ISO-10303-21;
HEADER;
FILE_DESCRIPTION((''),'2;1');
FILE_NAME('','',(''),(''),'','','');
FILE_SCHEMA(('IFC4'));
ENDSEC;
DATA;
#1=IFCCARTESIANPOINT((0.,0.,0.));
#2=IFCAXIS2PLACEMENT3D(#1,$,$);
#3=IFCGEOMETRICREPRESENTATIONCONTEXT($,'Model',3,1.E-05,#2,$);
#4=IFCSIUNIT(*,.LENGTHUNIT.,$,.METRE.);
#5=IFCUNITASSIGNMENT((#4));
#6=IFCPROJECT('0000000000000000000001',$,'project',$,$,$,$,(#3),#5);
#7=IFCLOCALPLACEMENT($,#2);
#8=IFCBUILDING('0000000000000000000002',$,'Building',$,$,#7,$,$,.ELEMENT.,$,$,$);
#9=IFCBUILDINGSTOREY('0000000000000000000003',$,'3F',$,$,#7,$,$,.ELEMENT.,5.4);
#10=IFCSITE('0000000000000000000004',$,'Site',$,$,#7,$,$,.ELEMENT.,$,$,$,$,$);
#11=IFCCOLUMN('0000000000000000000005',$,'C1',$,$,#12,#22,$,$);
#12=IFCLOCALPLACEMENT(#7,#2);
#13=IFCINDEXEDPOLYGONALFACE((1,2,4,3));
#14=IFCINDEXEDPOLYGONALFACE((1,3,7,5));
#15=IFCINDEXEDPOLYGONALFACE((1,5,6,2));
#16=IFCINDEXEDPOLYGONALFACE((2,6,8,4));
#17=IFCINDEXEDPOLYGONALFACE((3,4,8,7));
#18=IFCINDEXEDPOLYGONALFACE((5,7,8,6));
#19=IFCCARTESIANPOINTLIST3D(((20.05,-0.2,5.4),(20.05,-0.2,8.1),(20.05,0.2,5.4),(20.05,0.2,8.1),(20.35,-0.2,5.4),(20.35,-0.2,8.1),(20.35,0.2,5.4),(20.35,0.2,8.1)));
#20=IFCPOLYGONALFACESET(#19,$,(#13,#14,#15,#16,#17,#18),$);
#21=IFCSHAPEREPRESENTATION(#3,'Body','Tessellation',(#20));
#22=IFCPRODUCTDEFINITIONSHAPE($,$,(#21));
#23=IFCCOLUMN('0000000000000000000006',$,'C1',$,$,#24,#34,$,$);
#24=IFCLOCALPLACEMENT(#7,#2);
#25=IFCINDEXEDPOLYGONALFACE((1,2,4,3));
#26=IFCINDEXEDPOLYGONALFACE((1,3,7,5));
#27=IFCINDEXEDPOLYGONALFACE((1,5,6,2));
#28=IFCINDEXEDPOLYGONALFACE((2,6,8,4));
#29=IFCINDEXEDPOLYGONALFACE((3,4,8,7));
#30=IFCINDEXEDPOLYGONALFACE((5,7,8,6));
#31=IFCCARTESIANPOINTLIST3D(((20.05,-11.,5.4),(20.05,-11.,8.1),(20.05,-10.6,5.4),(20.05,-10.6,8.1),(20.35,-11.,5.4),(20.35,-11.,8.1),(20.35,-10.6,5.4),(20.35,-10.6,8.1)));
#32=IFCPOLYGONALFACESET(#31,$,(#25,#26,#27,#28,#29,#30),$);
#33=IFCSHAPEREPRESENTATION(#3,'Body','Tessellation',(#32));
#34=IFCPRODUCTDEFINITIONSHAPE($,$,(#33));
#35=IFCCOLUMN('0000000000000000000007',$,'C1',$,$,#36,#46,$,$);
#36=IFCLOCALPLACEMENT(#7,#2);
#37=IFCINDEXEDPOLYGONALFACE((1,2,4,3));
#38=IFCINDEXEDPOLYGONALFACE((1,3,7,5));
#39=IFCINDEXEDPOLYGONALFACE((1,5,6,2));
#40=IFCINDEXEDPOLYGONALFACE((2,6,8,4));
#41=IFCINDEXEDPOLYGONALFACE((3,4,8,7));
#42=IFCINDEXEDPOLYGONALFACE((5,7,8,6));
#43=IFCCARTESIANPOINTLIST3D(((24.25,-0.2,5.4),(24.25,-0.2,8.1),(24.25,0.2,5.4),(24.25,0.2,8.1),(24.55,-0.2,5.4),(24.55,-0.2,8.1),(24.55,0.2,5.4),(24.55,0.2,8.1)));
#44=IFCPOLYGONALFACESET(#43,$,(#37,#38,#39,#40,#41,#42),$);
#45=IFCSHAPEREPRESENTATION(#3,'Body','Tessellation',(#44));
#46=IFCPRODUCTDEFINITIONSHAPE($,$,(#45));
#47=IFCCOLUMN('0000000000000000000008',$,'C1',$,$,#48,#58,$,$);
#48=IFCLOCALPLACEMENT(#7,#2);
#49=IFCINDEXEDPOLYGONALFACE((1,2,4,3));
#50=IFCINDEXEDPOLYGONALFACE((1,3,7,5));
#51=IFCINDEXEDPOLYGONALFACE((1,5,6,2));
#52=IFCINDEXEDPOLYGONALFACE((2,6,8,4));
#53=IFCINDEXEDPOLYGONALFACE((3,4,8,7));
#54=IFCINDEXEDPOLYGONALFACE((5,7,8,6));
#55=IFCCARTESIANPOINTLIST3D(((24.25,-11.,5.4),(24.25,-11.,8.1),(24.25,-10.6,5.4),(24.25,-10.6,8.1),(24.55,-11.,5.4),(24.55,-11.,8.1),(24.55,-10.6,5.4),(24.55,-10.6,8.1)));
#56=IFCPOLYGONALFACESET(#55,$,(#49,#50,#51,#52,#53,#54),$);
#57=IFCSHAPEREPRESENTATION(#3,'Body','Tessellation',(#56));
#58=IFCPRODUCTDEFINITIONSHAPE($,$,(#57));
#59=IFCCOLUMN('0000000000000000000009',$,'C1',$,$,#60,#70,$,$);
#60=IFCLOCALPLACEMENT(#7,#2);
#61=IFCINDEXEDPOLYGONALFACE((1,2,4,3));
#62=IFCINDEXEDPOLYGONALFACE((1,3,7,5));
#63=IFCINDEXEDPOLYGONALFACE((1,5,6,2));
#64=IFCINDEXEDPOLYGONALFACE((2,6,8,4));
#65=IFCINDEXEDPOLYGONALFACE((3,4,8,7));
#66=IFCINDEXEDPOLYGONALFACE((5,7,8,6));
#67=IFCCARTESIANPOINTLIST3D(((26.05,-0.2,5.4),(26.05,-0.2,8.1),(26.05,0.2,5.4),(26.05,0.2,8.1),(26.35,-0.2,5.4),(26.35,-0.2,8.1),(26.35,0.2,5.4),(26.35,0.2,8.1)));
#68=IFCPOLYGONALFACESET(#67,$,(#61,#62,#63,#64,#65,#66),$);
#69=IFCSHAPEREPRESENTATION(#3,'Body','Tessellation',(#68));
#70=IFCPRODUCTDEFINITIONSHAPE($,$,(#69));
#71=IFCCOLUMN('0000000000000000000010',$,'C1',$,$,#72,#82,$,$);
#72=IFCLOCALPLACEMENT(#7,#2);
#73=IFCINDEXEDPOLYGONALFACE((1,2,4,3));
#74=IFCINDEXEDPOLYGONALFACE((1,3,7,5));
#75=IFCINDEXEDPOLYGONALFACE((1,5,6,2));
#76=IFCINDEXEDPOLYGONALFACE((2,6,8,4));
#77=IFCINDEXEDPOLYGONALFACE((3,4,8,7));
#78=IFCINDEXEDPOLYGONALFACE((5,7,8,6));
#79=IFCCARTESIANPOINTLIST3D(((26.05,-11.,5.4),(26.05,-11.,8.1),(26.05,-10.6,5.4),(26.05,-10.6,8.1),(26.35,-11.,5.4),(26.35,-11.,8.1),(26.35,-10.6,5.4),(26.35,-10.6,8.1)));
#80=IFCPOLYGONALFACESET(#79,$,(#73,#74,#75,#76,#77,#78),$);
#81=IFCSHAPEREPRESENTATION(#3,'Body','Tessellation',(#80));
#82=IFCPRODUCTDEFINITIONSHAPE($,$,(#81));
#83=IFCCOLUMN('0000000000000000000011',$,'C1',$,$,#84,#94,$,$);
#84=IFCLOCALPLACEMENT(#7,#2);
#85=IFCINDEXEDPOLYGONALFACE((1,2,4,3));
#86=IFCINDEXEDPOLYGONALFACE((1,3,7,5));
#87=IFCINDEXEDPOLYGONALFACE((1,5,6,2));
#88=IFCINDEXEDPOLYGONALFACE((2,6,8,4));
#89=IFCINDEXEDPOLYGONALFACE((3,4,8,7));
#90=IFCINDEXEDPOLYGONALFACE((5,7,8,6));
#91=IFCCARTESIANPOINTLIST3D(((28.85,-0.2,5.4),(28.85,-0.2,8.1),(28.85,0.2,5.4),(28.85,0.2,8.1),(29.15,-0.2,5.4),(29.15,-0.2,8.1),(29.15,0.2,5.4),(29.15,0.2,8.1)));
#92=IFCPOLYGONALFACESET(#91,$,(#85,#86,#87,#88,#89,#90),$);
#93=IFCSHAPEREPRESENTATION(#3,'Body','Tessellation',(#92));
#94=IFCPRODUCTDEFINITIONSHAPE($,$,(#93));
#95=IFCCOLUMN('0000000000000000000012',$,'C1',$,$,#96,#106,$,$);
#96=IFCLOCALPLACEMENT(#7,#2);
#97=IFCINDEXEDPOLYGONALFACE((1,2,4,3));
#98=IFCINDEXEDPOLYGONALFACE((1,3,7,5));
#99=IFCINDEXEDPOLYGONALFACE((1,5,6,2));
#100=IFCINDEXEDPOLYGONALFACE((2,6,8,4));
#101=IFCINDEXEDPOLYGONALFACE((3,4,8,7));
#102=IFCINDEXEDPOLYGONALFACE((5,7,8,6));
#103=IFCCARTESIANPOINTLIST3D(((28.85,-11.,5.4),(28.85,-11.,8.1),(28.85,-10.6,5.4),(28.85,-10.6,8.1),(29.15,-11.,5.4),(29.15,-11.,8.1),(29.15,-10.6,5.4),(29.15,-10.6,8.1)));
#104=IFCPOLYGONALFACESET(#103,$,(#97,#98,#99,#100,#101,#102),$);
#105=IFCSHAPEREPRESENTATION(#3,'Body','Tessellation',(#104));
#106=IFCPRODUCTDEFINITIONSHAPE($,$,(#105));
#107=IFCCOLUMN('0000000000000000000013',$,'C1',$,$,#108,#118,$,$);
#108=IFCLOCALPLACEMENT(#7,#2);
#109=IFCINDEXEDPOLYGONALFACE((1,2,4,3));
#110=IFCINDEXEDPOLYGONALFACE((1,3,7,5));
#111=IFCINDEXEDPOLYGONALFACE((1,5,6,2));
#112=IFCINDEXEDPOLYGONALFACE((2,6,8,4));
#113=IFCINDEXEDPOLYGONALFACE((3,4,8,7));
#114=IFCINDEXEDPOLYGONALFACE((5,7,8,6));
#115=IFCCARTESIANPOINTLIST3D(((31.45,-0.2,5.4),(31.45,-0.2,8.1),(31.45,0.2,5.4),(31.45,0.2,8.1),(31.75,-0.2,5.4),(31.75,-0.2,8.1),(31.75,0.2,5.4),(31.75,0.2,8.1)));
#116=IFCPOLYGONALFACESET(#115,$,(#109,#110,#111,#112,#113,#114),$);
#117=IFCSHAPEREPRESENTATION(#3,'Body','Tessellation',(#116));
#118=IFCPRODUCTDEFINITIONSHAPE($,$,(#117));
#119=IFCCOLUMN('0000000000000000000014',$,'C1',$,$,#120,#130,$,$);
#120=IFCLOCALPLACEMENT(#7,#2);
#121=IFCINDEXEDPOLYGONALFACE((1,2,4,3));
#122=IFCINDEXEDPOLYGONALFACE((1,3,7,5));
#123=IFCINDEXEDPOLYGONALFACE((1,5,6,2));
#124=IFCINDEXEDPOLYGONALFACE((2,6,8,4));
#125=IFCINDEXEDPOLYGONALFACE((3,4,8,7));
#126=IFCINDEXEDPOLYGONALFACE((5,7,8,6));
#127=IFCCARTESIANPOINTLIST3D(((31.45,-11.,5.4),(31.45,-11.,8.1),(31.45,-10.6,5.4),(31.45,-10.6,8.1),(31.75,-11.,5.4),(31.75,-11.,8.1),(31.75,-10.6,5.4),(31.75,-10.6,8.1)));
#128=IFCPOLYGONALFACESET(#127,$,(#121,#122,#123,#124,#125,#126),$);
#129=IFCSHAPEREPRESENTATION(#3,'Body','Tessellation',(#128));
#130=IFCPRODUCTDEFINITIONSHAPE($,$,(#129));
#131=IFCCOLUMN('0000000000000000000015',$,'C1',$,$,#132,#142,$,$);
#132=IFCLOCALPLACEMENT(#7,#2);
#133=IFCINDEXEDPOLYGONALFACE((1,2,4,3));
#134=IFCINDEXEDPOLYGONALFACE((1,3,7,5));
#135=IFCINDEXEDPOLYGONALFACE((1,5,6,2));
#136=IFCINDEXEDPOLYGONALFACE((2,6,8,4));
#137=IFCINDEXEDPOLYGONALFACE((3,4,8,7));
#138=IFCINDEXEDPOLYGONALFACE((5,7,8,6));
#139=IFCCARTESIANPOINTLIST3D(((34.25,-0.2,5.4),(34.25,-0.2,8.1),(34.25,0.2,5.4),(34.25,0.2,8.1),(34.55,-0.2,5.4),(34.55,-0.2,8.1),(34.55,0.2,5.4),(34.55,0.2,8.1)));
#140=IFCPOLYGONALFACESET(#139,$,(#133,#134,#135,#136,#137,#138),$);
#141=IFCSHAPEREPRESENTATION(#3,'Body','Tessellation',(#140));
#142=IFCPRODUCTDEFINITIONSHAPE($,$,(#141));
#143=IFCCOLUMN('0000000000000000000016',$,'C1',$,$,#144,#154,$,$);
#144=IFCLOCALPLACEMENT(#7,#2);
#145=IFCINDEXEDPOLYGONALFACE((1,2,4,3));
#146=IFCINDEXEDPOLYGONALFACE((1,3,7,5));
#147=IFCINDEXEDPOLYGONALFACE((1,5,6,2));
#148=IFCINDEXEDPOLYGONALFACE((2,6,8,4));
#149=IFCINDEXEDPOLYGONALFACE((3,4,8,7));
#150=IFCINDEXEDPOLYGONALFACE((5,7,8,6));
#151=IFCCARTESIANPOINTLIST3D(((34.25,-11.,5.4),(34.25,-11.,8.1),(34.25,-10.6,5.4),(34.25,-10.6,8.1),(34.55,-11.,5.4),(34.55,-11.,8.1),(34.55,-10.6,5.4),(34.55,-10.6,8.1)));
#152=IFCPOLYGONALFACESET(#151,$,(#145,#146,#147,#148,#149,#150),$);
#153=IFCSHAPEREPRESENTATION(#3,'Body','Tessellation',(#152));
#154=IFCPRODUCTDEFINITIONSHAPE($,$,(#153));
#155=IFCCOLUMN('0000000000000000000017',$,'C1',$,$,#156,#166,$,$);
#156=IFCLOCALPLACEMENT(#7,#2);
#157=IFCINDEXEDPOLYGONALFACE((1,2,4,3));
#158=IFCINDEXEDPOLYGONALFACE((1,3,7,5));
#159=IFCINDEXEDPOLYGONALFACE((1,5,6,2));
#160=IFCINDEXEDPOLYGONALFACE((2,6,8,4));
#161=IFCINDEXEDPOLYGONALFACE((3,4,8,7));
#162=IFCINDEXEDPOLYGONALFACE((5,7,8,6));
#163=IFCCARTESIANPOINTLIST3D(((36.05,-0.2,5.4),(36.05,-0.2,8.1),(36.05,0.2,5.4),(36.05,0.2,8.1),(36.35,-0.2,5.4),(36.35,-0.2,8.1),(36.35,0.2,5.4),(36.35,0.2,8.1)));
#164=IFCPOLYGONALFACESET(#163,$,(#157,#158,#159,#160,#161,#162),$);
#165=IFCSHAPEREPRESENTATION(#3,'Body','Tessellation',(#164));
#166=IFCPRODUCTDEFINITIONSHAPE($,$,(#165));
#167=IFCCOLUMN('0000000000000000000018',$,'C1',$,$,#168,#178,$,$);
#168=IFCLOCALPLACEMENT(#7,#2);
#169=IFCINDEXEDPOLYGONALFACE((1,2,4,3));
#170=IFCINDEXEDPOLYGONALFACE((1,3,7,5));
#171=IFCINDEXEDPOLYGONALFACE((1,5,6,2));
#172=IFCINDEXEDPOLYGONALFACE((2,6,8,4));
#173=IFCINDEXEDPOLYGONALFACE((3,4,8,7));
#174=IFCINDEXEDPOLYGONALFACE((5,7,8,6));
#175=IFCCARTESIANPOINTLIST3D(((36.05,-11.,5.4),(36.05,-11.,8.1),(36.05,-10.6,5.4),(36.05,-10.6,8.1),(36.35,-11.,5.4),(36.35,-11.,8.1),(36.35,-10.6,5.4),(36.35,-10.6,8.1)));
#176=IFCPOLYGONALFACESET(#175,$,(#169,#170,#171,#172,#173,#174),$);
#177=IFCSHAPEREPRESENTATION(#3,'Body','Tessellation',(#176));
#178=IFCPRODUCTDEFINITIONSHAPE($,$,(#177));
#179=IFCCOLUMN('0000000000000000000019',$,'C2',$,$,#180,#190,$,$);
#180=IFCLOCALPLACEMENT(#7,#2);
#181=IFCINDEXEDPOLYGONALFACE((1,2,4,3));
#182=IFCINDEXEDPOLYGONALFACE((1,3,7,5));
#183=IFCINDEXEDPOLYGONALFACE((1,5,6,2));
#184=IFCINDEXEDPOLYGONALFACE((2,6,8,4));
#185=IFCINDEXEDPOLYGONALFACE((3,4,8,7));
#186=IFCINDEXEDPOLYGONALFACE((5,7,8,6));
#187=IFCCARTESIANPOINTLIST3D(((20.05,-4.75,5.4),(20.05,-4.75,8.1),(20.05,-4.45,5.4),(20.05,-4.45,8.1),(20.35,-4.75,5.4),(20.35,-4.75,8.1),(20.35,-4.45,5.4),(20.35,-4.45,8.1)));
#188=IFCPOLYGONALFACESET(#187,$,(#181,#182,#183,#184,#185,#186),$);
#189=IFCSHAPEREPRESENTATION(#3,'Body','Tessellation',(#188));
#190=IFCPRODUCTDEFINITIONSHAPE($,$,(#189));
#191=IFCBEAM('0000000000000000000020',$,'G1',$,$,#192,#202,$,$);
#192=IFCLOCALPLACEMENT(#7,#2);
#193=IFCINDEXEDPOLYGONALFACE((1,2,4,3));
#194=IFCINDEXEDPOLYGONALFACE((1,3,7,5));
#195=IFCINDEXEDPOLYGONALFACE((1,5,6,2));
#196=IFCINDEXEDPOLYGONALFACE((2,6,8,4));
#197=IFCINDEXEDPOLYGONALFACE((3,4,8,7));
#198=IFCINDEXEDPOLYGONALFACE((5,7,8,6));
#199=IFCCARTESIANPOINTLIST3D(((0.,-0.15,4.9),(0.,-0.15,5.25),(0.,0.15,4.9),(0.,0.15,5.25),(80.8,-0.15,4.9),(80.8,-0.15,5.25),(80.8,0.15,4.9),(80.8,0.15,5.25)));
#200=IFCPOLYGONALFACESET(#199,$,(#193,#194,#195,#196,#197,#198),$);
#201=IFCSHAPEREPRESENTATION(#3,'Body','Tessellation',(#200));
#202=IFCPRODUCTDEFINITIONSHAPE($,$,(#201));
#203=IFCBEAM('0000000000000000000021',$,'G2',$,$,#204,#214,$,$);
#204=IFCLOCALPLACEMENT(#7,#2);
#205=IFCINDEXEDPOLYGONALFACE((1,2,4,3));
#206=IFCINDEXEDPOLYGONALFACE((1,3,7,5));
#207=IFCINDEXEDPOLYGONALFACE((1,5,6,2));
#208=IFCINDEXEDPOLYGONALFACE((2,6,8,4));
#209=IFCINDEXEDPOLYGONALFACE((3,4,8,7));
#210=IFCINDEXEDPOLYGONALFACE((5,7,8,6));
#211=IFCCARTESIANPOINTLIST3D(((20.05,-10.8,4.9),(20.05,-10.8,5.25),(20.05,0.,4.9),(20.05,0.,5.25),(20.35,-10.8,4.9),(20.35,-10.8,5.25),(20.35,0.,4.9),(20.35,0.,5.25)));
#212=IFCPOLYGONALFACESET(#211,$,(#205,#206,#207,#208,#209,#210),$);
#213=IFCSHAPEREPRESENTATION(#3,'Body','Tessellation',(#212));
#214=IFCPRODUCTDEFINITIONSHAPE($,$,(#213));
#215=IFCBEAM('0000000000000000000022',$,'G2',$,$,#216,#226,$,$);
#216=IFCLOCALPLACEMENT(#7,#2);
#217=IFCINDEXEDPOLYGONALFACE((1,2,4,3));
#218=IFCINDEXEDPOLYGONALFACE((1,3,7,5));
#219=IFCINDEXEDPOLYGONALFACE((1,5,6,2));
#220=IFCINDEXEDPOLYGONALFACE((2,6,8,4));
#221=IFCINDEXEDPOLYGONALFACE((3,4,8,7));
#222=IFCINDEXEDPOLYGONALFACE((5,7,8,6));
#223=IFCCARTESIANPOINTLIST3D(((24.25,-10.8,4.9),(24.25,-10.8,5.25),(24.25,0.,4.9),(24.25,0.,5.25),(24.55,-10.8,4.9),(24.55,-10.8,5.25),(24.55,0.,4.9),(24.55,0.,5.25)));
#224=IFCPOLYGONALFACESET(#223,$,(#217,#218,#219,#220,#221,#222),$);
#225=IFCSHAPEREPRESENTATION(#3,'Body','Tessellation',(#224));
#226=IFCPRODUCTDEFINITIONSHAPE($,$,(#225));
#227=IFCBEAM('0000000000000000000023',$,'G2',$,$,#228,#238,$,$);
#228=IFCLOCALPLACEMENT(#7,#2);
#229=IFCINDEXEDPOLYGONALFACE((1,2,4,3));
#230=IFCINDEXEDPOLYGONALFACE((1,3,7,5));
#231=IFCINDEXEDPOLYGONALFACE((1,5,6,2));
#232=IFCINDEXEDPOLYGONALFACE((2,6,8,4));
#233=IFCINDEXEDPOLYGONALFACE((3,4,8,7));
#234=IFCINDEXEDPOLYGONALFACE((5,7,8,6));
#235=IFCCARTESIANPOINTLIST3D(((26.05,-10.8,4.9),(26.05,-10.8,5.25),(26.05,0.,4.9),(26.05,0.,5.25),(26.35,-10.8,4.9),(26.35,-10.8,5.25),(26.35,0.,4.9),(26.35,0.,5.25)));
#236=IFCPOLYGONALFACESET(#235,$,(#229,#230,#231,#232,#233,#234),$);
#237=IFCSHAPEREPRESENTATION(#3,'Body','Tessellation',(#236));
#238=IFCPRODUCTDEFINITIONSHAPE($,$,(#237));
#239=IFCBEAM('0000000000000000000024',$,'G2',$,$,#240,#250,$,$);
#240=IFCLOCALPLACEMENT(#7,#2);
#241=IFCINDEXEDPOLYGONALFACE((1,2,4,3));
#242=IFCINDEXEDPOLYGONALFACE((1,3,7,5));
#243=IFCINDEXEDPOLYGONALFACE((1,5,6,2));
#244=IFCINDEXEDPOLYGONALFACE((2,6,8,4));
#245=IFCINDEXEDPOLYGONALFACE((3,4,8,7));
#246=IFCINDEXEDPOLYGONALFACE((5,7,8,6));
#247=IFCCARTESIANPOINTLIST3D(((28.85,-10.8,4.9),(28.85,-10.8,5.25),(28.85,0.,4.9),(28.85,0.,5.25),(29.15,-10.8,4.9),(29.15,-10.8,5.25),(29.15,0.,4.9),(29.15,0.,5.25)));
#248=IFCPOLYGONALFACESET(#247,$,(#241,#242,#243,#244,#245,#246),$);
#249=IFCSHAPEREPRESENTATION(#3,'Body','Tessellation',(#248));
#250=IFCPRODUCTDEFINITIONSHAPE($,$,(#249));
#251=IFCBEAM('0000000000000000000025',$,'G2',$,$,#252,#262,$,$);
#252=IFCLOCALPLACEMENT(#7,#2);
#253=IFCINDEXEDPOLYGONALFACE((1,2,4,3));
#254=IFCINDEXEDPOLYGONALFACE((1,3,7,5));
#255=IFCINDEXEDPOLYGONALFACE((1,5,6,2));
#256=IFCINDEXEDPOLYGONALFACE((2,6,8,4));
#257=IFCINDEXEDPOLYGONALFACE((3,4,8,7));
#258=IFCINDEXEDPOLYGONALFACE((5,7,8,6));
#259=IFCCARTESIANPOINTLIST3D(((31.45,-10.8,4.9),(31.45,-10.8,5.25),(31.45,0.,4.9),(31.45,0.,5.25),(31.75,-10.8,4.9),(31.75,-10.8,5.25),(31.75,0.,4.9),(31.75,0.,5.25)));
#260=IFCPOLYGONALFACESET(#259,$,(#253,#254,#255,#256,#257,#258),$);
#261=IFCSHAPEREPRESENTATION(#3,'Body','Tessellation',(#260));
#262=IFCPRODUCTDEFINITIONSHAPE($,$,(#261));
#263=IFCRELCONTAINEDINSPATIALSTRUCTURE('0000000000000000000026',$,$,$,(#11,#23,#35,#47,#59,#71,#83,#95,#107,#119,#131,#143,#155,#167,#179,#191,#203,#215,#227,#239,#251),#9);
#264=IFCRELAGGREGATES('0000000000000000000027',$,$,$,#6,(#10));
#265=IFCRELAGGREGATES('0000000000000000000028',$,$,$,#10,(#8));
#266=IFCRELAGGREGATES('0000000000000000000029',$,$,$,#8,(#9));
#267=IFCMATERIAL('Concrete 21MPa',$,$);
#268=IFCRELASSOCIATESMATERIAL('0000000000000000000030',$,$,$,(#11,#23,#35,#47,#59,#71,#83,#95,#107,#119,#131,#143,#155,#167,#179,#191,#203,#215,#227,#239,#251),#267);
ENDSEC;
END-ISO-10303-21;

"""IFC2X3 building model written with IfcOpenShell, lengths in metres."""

from ifc_helpers import new_model, si_unit, frame, origin, origin_2d, place, context, project, spatial, rectangle, extrude, material, element, save


model = new_model("IFC2X3")

# Units and contexts
model_context = context("Model", 3, precision=1e-05, world=origin())
ifc_project = project(units=[si_unit("LENGTHUNIT", "METRE")], contexts=[model_context])

# Site, building, storey
placement = place(None, origin())
site = spatial("IfcSite", under=ifc_project, at=placement, Name="Site", CompositionType="ELEMENT")
building = spatial("IfcBuilding", under=site, at=placement, Name="Building", CompositionType="ELEMENT")
storey = spatial("IfcBuildingStorey", under=building, at=placement, Name="3F", CompositionType="ELEMENT", Elevation=5.4)

# Columns
ifc_material_1 = material(Name="Concrete 21MPa")
for number, where, name in (
    (1, (20.2, 0.0, 5.4), "C1"),
    (2, (20.2, -10.8, 5.4), "C1"),
    (3, (24.4, 0.0, 5.4), "C1"),
    (4, (24.4, -10.8, 5.4), "C1"),
    (5, (26.2, 0.0, 5.4), "C1"),
    (6, (26.2, -10.8, 5.4), "C1"),
    (7, (29.0, 0.0, 5.4), "C1"),
    (8, (29.0, -10.8, 5.4), "C1"),
    (9, (31.6, 0.0, 5.4), "C1"),
    (10, (31.6, -10.8, 5.4), "C1"),
    (11, (34.4, 0.0, 5.4), "C1"),
    (12, (34.4, -10.8, 5.4), "C1"),
    (13, (36.2, 0.0, 5.4), "C1"),
    (14, (36.2, -10.8, 5.4), "C1"),
):
    element("IfcColumn", number, at=place(None, frame(where)), inside=storey, material=ifc_material_1, Name=name, context=model_context, shape_type="SweptSolid", body=[
        extrude(rectangle(XDim=0.3, YDim=0.4, at=origin_2d()), origin(), (0.0, 0.0, 1.0), 2.7),
    ])
column_placement = place(None, frame((20.2, -4.6, 5.4)))
element("IfcColumn", 15, at=column_placement, inside=storey, material=ifc_material_1, Name="C2", context=model_context, shape_type="SweptSolid", body=[
    extrude(rectangle(XDim=0.3, YDim=0.3, at=origin_2d()), origin(), (0.0, 0.0, 1.0), 2.7),
])

# Beams
beam_placement = place(None, frame((40.4, 0.0, 4.9)))
element("IfcBeam", 16, at=beam_placement, inside=storey, material=ifc_material_1, Name="G1", context=model_context, shape_type="SweptSolid", body=[
    extrude(rectangle(XDim=80.8, YDim=0.3, at=origin_2d()), origin(), (0.0, 0.0, 1.0), 0.35),
])
for number, where, name in (
    (17, (20.2, -5.4, 4.9), "G2"),
    (18, (24.4, -5.4, 4.9), "G2"),
    (19, (26.2, -5.4, 4.9), "G2"),
    (20, (29.0, -5.4, 4.9), "G2"),
    (21, (31.6, -5.4, 4.9), "G2"),
):
    element("IfcBeam", number, at=place(None, frame(where)), inside=storey, material=ifc_material_1, Name=name, context=model_context, shape_type="SweptSolid", body=[
        extrude(rectangle(XDim=0.3, YDim=10.8, at=origin_2d()), origin(), (0.0, 0.0, 1.0), 0.35),
    ])

save(model, "model.ifc")
